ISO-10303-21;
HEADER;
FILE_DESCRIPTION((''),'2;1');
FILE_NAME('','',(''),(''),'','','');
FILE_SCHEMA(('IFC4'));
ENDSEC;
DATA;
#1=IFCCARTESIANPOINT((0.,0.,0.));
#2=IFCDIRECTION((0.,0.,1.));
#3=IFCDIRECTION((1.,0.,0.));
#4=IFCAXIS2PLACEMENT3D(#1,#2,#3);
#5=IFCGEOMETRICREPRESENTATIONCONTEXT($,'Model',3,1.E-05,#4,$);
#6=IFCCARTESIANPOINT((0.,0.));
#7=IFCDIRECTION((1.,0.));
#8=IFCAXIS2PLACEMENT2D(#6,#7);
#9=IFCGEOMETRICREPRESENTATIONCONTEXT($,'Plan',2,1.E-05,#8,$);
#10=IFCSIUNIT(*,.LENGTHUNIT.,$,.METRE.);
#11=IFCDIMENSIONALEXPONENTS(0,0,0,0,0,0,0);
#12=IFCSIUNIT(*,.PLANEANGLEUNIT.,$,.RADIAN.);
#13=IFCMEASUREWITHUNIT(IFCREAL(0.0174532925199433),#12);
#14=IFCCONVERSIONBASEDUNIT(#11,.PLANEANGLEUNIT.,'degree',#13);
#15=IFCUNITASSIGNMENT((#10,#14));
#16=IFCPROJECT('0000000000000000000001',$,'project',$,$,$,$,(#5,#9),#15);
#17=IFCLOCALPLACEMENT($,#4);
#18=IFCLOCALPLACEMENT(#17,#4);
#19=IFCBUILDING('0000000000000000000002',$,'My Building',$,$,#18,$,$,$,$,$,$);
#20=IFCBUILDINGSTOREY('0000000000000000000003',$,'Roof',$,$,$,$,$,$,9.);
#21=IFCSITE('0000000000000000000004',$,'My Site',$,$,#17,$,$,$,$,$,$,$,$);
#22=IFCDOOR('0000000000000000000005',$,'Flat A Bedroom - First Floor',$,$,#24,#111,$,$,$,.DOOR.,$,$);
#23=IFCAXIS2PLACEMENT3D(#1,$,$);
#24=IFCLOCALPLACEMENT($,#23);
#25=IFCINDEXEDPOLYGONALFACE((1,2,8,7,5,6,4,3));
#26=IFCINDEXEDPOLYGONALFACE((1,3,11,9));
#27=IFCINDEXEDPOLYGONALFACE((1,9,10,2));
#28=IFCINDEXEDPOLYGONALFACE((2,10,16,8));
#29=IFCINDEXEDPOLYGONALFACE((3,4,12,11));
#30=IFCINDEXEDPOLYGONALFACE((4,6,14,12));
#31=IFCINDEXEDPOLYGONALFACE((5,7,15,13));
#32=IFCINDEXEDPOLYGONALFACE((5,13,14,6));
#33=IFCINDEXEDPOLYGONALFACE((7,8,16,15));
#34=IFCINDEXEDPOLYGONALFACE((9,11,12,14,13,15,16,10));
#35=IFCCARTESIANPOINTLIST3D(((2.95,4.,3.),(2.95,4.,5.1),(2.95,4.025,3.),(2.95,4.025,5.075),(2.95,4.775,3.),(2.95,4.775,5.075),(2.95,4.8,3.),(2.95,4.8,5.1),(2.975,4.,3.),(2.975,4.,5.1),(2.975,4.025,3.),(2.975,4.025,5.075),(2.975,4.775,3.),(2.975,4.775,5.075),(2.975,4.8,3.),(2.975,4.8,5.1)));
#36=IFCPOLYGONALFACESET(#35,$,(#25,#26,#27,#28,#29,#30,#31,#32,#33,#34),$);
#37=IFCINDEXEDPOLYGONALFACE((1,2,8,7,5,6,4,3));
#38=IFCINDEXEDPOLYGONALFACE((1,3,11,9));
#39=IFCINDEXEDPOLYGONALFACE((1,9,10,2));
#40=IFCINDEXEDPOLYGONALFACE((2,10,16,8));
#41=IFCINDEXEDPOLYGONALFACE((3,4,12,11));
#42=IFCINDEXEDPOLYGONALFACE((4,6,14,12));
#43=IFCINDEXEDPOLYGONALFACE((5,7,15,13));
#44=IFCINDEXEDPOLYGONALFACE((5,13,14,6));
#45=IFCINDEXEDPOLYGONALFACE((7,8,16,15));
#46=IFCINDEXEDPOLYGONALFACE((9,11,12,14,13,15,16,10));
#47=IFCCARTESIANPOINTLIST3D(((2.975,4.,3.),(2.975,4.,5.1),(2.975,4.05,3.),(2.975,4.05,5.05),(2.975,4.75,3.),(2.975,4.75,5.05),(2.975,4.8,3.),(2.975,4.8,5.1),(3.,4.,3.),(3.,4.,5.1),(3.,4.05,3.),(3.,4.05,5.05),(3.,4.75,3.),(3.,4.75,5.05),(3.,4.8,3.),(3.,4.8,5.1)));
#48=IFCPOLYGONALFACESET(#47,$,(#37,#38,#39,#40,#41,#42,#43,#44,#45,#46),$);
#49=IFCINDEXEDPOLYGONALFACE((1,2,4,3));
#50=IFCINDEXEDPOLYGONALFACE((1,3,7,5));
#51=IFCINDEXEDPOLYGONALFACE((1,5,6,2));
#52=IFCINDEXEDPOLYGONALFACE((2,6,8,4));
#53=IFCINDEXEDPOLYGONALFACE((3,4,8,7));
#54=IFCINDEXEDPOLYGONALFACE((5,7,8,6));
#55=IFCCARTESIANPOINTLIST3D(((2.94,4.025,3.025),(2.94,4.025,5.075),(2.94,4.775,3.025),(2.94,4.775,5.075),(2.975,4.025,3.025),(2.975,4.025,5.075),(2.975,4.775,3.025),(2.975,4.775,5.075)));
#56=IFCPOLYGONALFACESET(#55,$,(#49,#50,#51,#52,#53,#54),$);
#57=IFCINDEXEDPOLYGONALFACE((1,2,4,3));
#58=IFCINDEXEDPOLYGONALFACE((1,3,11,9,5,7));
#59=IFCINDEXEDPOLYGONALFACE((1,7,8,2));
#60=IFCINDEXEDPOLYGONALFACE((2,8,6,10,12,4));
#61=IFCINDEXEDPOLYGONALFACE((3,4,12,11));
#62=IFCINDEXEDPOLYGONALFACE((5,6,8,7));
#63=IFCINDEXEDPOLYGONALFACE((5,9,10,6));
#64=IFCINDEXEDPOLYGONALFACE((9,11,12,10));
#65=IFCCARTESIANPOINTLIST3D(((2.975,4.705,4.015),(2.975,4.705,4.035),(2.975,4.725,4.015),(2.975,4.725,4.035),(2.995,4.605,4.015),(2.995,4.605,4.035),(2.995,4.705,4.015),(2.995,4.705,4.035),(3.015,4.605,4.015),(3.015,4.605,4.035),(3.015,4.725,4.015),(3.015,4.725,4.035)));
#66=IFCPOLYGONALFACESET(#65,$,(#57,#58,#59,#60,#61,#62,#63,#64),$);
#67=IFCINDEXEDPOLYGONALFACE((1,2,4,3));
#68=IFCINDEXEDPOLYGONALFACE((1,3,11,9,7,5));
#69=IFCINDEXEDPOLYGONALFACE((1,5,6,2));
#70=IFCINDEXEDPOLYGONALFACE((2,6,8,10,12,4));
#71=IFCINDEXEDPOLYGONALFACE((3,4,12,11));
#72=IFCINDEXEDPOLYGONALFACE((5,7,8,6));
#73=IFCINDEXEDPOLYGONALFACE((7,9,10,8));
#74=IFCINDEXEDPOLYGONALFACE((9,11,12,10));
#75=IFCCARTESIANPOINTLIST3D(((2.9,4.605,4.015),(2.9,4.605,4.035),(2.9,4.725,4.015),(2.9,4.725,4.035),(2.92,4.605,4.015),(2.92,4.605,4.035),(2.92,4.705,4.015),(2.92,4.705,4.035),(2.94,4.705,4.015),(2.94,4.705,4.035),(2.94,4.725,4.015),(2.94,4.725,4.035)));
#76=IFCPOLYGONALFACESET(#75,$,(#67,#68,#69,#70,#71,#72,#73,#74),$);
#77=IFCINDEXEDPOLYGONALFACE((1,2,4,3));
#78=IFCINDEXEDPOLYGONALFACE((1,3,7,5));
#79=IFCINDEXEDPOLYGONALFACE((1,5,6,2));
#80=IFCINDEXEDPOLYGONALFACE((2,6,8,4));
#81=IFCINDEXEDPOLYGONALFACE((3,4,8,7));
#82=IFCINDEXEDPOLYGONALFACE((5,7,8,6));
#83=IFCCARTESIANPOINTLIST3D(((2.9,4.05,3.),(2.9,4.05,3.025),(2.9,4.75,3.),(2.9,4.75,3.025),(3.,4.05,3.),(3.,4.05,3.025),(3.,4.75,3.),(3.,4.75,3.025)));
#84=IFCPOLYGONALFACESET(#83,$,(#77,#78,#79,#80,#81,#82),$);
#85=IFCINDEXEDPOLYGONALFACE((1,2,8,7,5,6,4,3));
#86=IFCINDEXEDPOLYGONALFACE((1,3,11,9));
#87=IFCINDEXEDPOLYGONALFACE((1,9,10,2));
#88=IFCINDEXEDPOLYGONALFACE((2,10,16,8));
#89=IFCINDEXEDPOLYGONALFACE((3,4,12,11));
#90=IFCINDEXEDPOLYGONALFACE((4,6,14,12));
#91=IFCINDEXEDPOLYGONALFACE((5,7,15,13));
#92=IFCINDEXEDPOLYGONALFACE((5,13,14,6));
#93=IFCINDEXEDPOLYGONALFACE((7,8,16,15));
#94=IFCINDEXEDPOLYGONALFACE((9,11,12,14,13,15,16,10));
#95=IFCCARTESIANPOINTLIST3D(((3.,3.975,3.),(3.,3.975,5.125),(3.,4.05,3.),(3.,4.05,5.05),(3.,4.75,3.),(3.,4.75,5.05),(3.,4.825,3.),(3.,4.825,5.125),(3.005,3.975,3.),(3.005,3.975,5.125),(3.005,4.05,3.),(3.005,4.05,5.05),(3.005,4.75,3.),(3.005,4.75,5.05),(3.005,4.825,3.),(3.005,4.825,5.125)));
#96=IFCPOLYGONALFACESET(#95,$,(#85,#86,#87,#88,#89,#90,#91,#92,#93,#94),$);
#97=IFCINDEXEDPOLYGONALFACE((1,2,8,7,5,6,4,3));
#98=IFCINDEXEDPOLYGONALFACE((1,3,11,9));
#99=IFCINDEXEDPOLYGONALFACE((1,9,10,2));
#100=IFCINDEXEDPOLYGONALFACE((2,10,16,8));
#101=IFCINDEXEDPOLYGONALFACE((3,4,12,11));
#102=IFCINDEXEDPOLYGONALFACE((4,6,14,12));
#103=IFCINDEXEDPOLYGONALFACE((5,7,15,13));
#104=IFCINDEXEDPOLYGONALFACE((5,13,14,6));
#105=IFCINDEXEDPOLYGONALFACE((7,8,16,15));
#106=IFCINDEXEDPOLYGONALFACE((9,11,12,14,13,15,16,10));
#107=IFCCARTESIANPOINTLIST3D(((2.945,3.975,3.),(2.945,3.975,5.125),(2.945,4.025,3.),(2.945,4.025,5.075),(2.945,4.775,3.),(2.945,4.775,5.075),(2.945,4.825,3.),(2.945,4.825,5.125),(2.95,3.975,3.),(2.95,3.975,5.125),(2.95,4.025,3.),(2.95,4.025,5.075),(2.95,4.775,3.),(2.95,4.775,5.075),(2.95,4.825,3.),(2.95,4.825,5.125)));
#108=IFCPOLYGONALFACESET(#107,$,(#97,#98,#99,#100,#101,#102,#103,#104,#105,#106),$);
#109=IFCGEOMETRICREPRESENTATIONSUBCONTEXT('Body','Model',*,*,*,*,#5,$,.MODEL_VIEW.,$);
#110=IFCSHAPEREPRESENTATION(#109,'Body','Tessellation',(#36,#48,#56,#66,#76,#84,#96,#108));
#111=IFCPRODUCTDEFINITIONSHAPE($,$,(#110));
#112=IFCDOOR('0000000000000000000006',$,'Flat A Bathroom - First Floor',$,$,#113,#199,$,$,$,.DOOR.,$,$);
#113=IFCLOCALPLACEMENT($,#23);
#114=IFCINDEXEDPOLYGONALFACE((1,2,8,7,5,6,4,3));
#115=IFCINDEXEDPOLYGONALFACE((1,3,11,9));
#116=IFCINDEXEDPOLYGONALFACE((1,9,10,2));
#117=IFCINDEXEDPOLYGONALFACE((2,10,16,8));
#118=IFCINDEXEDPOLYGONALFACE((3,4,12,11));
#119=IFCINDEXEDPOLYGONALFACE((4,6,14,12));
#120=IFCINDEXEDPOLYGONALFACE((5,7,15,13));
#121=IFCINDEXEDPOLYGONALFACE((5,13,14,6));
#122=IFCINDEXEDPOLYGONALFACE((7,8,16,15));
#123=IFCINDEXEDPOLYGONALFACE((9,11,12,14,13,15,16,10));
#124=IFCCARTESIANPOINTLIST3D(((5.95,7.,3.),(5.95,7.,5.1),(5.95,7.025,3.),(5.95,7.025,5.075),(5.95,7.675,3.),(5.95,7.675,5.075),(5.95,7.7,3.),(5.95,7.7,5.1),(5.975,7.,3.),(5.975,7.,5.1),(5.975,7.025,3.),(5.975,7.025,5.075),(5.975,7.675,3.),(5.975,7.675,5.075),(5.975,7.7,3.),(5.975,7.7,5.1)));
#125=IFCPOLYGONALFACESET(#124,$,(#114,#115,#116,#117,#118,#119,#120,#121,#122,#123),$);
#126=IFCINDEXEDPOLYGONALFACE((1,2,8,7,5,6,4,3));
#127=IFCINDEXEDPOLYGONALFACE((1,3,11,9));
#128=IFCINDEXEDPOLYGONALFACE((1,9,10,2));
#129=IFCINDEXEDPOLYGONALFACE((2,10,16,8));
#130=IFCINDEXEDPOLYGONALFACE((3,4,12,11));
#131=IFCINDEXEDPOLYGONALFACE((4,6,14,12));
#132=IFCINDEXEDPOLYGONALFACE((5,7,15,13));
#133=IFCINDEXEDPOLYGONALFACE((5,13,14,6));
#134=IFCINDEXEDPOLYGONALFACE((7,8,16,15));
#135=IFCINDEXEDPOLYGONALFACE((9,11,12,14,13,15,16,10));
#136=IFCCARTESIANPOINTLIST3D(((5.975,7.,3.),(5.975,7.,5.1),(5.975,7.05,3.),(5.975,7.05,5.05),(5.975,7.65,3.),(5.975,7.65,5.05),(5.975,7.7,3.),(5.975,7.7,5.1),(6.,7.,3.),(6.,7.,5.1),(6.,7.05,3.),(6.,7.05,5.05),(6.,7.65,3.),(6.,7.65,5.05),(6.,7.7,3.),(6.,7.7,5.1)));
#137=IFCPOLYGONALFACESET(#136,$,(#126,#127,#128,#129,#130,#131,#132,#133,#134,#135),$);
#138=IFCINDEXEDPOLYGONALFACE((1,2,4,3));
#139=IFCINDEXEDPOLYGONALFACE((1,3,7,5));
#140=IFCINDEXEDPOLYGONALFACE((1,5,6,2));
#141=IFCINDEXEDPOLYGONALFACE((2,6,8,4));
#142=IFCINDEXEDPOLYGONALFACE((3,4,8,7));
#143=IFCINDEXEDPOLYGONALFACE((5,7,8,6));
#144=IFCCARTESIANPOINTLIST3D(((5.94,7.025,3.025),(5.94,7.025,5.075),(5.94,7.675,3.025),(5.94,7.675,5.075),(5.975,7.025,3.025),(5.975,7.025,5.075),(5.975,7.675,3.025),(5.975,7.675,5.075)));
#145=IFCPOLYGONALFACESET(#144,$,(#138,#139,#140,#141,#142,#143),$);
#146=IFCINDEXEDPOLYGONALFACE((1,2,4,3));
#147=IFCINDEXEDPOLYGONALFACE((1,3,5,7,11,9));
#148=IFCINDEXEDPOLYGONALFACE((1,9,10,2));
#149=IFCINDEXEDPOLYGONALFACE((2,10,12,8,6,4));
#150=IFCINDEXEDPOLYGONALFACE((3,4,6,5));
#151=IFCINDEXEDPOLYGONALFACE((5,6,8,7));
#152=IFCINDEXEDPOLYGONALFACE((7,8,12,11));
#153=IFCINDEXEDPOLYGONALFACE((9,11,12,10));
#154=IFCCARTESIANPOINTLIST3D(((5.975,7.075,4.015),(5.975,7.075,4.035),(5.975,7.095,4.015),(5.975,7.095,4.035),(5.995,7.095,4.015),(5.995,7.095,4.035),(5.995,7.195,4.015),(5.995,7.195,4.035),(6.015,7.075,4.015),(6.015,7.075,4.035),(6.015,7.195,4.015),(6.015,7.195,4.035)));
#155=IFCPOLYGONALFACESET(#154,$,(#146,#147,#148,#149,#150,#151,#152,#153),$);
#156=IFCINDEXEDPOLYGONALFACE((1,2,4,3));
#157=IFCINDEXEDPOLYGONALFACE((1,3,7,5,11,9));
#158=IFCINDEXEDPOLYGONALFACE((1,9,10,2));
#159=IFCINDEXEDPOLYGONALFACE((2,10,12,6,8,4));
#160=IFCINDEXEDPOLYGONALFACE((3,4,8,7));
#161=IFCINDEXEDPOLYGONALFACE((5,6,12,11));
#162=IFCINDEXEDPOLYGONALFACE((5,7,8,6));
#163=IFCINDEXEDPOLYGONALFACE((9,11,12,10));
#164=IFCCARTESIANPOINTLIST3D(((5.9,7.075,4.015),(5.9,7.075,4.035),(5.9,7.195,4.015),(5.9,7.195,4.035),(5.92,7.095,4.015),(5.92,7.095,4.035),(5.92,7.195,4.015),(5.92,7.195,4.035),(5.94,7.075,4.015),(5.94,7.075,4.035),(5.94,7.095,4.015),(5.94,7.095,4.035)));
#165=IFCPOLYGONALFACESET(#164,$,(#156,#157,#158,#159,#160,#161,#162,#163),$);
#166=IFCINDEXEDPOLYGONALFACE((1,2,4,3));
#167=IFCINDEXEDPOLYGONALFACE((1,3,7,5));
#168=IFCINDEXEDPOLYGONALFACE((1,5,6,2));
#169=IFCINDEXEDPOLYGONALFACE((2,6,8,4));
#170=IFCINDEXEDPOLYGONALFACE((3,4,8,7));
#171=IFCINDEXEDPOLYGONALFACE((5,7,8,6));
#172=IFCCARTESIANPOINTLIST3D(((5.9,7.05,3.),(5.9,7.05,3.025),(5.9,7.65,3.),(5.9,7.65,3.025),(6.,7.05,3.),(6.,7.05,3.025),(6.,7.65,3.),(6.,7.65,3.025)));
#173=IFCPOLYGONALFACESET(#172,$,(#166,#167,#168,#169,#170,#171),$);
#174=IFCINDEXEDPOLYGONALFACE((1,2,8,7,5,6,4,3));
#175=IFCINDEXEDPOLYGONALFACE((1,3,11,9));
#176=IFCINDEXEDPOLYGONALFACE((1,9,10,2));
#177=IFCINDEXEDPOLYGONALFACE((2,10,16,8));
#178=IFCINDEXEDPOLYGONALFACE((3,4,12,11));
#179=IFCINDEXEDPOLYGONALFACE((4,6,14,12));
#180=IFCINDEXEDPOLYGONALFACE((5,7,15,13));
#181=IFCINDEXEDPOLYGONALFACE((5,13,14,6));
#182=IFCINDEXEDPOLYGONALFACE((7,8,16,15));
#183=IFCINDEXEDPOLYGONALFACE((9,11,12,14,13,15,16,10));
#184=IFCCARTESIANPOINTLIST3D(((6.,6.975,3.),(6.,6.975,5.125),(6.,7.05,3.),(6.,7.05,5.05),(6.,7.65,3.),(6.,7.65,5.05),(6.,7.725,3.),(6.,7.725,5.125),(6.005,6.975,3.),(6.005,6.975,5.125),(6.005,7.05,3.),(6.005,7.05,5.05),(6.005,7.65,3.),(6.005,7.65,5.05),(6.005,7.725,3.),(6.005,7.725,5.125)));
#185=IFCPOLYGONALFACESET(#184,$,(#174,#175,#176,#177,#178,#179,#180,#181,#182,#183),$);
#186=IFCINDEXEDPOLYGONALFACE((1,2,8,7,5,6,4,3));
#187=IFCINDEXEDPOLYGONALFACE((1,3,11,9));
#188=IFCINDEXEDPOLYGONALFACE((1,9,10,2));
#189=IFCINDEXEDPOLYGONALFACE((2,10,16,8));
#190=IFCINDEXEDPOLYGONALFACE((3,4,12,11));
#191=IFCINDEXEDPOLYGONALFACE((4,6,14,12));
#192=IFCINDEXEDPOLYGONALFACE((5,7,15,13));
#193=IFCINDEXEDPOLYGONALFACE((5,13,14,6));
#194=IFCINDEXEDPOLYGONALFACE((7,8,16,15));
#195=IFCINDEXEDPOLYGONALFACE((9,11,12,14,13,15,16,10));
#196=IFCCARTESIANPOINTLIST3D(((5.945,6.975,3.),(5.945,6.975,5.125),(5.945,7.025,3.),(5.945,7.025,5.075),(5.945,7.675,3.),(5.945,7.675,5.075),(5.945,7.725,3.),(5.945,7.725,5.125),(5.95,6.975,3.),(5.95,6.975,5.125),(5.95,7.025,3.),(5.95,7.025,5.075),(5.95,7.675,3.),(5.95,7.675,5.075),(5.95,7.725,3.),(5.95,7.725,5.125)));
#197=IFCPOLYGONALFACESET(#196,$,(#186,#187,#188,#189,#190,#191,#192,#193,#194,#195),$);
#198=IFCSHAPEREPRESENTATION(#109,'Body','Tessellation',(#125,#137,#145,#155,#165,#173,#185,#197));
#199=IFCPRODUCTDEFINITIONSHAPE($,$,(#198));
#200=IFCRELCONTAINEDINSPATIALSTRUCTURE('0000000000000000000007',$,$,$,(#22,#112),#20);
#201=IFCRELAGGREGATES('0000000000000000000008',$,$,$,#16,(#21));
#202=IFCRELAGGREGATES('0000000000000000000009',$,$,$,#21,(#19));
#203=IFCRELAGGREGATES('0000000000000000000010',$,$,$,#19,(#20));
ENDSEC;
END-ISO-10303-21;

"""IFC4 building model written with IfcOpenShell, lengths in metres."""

from ifc_helpers import new_model, entity, si_unit, converted_unit, frame, origin_with_axes, origin_2d_with_axis, place, context, subcontext, project, spatial, line, indexed_curve, outline, extrude, element, save


model = new_model("IFC4")

# Units and contexts
model_context = context("Model", 3, precision=1e-05, world=origin_with_axes())
plan_context = context("Plan", 2, precision=1e-05, world=origin_2d_with_axis())
body_context = subcontext(model_context, "Body", "Model", "MODEL_VIEW")
ifc_project = project(units=[si_unit("LENGTHUNIT", "METRE"), converted_unit("PLANEANGLEUNIT", "degree", entity("IfcReal", 0.0174532925199433), si_unit("PLANEANGLEUNIT", "RADIAN"), dimensions=[0, 0, 0, 0, 0, 0, 0])], contexts=[model_context, plan_context])

# Site, building, storey
site_placement = place(None, origin_with_axes())
site = spatial("IfcSite", under=ifc_project, at=site_placement, Name="My Site")
building_placement = place(site_placement, origin_with_axes())
building = spatial("IfcBuilding", under=site, at=building_placement, Name="My Building")
storey = spatial("IfcBuildingStorey", under=building, Name="Roof", Elevation=9.0)

# Doors
door_1_placement = place(None, frame((3.0, 4.0, 3.0), z_axis=(0.0, 0.0, 1.0), x_axis=(0.0, 1.0, 0.0)))
element("IfcDoor", 1, at=door_1_placement, inside=storey, Name="Flat A Bedroom - First Floor", PredefinedType="DOOR", context=body_context, shape_type="SweptSolid", body=[
    extrude(outline(indexed_curve([(0.0, 0.0), (0.0, 2.1), (0.8, 2.1), (0.8, 0.0), (0.775, 0.0), (0.775, 2.075), (0.025, 2.075), (0.025, 0.0)], segments=[line(1, 2, 3, 4, 5, 6, 7, 8, 1)])), frame((0.0, 0.025, 0.0), z_axis=(0.0, -1.0, 0.0), x_axis=(1.0, 0.0, 0.0)), (0.0, 0.0, -1.0), 0.025),
    extrude(outline(indexed_curve([(0.0, 0.0), (0.0, 2.1), (0.8, 2.1), (0.8, 0.0), (0.75, 0.0), (0.75, 2.05), (0.05, 2.05), (0.05, 0.0)], segments=[line(1, 2, 3, 4, 5, 6, 7, 8, 1)])), frame((0.0, 0.0, 0.0), z_axis=(0.0, -1.0, 0.0), x_axis=(1.0, 0.0, 0.0)), (0.0, 0.0, -1.0), 0.025),
    extrude(outline(indexed_curve([(0.0, 0.0), (0.75, 0.0), (0.75, 0.035), (0.0, 0.035)], segments=[line(1, 2, 3, 4, 1)])), frame((0.025, 0.025, 0.025), z_axis=(0.0, 0.0, 1.0), x_axis=(1.0, 0.0, 0.0)), (0.0, 0.0, 1.0), 2.05),
    extrude(outline(indexed_curve([(0.0, 0.0), (0.0, -0.04), (-0.12, -0.04), (-0.12, -0.02), (-0.02, -0.02), (-0.02, 0.0)], segments=[line(1, 2, 3, 4, 5, 6, 1)])), frame((0.725, 0.025, 1.015), z_axis=(0.0, 0.0, 1.0), x_axis=(1.0, 0.0, 0.0)), (0.0, 0.0, 1.0), 0.02),
    extrude(outline(indexed_curve([(0.0, 0.0), (0.0, 0.04), (-0.12, 0.04), (-0.12, 0.02), (-0.02, 0.02), (-0.02, 0.0)], segments=[line(1, 2, 3, 4, 5, 6, 1)])), frame((0.725, 0.06, 1.015), z_axis=(0.0, 0.0, 1.0), x_axis=(1.0, 0.0, 0.0)), (0.0, 0.0, 1.0), 0.02),
    extrude(outline(indexed_curve([(0.0, 0.0), (0.7, 0.0), (0.7, 0.1), (0.0, 0.1)], segments=[line(1, 2, 3, 4, 1)])), frame((0.05, 0.0, 0.0), z_axis=(0.0, 0.0, 1.0), x_axis=(1.0, 0.0, 0.0)), (0.0, 0.0, 1.0), 0.025),
    extrude(outline(indexed_curve([(0.0, 0.0), (0.0, 2.125), (0.85, 2.125), (0.85, 0.0), (0.775, 0.0), (0.775, 2.05), (0.075, 2.05), (0.075, 0.0)], segments=[line(1, 2, 3, 4, 5, 6, 7, 8, 1)])), frame((-0.025, -0.005, 0.0), z_axis=(0.0, -1.0, 0.0), x_axis=(1.0, 0.0, 0.0)), (0.0, 0.0, -1.0), 0.005),
    extrude(outline(indexed_curve([(0.0, 0.0), (0.0, 2.125), (0.85, 2.125), (0.85, 0.0), (0.8, 0.0), (0.8, 2.075), (0.05, 2.075), (0.05, 0.0)], segments=[line(1, 2, 3, 4, 5, 6, 7, 8, 1)])), frame((-0.025, 0.05, 0.0), z_axis=(0.0, -1.0, 0.0), x_axis=(1.0, 0.0, 0.0)), (0.0, 0.0, -1.0), 0.005),
])
door_2_placement = place(None, frame((6.0, 7.0, 3.0), z_axis=(0.0, 0.0, 1.0), x_axis=(0.0, 1.0, 0.0)))
element("IfcDoor", 2, at=door_2_placement, inside=storey, Name="Flat A Bathroom - First Floor", PredefinedType="DOOR", context=body_context, shape_type="SweptSolid", body=[
    extrude(outline(indexed_curve([(0.0, 0.0), (0.0, 2.1), (0.7, 2.1), (0.7, 0.0), (0.675, 0.0), (0.675, 2.075), (0.025, 2.075), (0.025, 0.0)], segments=[line(1, 2, 3, 4, 5, 6, 7, 8, 1)])), frame((0.0, 0.025, 0.0), z_axis=(0.0, -1.0, 0.0), x_axis=(1.0, 0.0, 0.0)), (0.0, 0.0, -1.0), 0.025),
    extrude(outline(indexed_curve([(0.0, 0.0), (0.0, 2.1), (0.7, 2.1), (0.7, 0.0), (0.65, 0.0), (0.65, 2.05), (0.05, 2.05), (0.05, 0.0)], segments=[line(1, 2, 3, 4, 5, 6, 7, 8, 1)])), frame((0.0, 0.0, 0.0), z_axis=(0.0, -1.0, 0.0), x_axis=(1.0, 0.0, 0.0)), (0.0, 0.0, -1.0), 0.025),
    extrude(outline(indexed_curve([(0.0, 0.0), (0.65, 0.0), (0.65, 0.035), (0.0, 0.035)], segments=[line(1, 2, 3, 4, 1)])), frame((0.025, 0.025, 0.025), z_axis=(0.0, 0.0, 1.0), x_axis=(1.0, 0.0, 0.0)), (0.0, 0.0, 1.0), 2.05),
    extrude(outline(indexed_curve([(0.0, 0.0), (0.0, -0.04), (0.12, -0.04), (0.12, -0.02), (0.02, -0.02), (0.02, 0.0)], segments=[line(1, 2, 3, 4, 5, 6, 1)])), frame((0.075, 0.025, 1.015), z_axis=(0.0, 0.0, 1.0), x_axis=(1.0, 0.0, 0.0)), (0.0, 0.0, 1.0), 0.02),
    extrude(outline(indexed_curve([(0.0, 0.0), (0.0, 0.04), (0.12, 0.04), (0.12, 0.02), (0.02, 0.02), (0.02, 0.0)], segments=[line(1, 2, 3, 4, 5, 6, 1)])), frame((0.075, 0.06, 1.015), z_axis=(0.0, 0.0, 1.0), x_axis=(1.0, 0.0, 0.0)), (0.0, 0.0, 1.0), 0.02),
    extrude(outline(indexed_curve([(0.0, 0.0), (0.6, 0.0), (0.6, 0.1), (0.0, 0.1)], segments=[line(1, 2, 3, 4, 1)])), frame((0.05, 0.0, 0.0), z_axis=(0.0, 0.0, 1.0), x_axis=(1.0, 0.0, 0.0)), (0.0, 0.0, 1.0), 0.025),
    extrude(outline(indexed_curve([(0.0, 0.0), (0.0, 2.125), (0.75, 2.125), (0.75, 0.0), (0.675, 0.0), (0.675, 2.05), (0.075, 2.05), (0.075, 0.0)], segments=[line(1, 2, 3, 4, 5, 6, 7, 8, 1)])), frame((-0.025, -0.005, 0.0), z_axis=(0.0, -1.0, 0.0), x_axis=(1.0, 0.0, 0.0)), (0.0, 0.0, -1.0), 0.005),
    extrude(outline(indexed_curve([(0.0, 0.0), (0.0, 2.125), (0.75, 2.125), (0.75, 0.0), (0.7, 0.0), (0.7, 2.075), (0.05, 2.075), (0.05, 0.0)], segments=[line(1, 2, 3, 4, 5, 6, 7, 8, 1)])), frame((-0.025, 0.05, 0.0), z_axis=(0.0, -1.0, 0.0), x_axis=(1.0, 0.0, 0.0)), (0.0, 0.0, -1.0), 0.005),
])

save(model, "model.ifc")
